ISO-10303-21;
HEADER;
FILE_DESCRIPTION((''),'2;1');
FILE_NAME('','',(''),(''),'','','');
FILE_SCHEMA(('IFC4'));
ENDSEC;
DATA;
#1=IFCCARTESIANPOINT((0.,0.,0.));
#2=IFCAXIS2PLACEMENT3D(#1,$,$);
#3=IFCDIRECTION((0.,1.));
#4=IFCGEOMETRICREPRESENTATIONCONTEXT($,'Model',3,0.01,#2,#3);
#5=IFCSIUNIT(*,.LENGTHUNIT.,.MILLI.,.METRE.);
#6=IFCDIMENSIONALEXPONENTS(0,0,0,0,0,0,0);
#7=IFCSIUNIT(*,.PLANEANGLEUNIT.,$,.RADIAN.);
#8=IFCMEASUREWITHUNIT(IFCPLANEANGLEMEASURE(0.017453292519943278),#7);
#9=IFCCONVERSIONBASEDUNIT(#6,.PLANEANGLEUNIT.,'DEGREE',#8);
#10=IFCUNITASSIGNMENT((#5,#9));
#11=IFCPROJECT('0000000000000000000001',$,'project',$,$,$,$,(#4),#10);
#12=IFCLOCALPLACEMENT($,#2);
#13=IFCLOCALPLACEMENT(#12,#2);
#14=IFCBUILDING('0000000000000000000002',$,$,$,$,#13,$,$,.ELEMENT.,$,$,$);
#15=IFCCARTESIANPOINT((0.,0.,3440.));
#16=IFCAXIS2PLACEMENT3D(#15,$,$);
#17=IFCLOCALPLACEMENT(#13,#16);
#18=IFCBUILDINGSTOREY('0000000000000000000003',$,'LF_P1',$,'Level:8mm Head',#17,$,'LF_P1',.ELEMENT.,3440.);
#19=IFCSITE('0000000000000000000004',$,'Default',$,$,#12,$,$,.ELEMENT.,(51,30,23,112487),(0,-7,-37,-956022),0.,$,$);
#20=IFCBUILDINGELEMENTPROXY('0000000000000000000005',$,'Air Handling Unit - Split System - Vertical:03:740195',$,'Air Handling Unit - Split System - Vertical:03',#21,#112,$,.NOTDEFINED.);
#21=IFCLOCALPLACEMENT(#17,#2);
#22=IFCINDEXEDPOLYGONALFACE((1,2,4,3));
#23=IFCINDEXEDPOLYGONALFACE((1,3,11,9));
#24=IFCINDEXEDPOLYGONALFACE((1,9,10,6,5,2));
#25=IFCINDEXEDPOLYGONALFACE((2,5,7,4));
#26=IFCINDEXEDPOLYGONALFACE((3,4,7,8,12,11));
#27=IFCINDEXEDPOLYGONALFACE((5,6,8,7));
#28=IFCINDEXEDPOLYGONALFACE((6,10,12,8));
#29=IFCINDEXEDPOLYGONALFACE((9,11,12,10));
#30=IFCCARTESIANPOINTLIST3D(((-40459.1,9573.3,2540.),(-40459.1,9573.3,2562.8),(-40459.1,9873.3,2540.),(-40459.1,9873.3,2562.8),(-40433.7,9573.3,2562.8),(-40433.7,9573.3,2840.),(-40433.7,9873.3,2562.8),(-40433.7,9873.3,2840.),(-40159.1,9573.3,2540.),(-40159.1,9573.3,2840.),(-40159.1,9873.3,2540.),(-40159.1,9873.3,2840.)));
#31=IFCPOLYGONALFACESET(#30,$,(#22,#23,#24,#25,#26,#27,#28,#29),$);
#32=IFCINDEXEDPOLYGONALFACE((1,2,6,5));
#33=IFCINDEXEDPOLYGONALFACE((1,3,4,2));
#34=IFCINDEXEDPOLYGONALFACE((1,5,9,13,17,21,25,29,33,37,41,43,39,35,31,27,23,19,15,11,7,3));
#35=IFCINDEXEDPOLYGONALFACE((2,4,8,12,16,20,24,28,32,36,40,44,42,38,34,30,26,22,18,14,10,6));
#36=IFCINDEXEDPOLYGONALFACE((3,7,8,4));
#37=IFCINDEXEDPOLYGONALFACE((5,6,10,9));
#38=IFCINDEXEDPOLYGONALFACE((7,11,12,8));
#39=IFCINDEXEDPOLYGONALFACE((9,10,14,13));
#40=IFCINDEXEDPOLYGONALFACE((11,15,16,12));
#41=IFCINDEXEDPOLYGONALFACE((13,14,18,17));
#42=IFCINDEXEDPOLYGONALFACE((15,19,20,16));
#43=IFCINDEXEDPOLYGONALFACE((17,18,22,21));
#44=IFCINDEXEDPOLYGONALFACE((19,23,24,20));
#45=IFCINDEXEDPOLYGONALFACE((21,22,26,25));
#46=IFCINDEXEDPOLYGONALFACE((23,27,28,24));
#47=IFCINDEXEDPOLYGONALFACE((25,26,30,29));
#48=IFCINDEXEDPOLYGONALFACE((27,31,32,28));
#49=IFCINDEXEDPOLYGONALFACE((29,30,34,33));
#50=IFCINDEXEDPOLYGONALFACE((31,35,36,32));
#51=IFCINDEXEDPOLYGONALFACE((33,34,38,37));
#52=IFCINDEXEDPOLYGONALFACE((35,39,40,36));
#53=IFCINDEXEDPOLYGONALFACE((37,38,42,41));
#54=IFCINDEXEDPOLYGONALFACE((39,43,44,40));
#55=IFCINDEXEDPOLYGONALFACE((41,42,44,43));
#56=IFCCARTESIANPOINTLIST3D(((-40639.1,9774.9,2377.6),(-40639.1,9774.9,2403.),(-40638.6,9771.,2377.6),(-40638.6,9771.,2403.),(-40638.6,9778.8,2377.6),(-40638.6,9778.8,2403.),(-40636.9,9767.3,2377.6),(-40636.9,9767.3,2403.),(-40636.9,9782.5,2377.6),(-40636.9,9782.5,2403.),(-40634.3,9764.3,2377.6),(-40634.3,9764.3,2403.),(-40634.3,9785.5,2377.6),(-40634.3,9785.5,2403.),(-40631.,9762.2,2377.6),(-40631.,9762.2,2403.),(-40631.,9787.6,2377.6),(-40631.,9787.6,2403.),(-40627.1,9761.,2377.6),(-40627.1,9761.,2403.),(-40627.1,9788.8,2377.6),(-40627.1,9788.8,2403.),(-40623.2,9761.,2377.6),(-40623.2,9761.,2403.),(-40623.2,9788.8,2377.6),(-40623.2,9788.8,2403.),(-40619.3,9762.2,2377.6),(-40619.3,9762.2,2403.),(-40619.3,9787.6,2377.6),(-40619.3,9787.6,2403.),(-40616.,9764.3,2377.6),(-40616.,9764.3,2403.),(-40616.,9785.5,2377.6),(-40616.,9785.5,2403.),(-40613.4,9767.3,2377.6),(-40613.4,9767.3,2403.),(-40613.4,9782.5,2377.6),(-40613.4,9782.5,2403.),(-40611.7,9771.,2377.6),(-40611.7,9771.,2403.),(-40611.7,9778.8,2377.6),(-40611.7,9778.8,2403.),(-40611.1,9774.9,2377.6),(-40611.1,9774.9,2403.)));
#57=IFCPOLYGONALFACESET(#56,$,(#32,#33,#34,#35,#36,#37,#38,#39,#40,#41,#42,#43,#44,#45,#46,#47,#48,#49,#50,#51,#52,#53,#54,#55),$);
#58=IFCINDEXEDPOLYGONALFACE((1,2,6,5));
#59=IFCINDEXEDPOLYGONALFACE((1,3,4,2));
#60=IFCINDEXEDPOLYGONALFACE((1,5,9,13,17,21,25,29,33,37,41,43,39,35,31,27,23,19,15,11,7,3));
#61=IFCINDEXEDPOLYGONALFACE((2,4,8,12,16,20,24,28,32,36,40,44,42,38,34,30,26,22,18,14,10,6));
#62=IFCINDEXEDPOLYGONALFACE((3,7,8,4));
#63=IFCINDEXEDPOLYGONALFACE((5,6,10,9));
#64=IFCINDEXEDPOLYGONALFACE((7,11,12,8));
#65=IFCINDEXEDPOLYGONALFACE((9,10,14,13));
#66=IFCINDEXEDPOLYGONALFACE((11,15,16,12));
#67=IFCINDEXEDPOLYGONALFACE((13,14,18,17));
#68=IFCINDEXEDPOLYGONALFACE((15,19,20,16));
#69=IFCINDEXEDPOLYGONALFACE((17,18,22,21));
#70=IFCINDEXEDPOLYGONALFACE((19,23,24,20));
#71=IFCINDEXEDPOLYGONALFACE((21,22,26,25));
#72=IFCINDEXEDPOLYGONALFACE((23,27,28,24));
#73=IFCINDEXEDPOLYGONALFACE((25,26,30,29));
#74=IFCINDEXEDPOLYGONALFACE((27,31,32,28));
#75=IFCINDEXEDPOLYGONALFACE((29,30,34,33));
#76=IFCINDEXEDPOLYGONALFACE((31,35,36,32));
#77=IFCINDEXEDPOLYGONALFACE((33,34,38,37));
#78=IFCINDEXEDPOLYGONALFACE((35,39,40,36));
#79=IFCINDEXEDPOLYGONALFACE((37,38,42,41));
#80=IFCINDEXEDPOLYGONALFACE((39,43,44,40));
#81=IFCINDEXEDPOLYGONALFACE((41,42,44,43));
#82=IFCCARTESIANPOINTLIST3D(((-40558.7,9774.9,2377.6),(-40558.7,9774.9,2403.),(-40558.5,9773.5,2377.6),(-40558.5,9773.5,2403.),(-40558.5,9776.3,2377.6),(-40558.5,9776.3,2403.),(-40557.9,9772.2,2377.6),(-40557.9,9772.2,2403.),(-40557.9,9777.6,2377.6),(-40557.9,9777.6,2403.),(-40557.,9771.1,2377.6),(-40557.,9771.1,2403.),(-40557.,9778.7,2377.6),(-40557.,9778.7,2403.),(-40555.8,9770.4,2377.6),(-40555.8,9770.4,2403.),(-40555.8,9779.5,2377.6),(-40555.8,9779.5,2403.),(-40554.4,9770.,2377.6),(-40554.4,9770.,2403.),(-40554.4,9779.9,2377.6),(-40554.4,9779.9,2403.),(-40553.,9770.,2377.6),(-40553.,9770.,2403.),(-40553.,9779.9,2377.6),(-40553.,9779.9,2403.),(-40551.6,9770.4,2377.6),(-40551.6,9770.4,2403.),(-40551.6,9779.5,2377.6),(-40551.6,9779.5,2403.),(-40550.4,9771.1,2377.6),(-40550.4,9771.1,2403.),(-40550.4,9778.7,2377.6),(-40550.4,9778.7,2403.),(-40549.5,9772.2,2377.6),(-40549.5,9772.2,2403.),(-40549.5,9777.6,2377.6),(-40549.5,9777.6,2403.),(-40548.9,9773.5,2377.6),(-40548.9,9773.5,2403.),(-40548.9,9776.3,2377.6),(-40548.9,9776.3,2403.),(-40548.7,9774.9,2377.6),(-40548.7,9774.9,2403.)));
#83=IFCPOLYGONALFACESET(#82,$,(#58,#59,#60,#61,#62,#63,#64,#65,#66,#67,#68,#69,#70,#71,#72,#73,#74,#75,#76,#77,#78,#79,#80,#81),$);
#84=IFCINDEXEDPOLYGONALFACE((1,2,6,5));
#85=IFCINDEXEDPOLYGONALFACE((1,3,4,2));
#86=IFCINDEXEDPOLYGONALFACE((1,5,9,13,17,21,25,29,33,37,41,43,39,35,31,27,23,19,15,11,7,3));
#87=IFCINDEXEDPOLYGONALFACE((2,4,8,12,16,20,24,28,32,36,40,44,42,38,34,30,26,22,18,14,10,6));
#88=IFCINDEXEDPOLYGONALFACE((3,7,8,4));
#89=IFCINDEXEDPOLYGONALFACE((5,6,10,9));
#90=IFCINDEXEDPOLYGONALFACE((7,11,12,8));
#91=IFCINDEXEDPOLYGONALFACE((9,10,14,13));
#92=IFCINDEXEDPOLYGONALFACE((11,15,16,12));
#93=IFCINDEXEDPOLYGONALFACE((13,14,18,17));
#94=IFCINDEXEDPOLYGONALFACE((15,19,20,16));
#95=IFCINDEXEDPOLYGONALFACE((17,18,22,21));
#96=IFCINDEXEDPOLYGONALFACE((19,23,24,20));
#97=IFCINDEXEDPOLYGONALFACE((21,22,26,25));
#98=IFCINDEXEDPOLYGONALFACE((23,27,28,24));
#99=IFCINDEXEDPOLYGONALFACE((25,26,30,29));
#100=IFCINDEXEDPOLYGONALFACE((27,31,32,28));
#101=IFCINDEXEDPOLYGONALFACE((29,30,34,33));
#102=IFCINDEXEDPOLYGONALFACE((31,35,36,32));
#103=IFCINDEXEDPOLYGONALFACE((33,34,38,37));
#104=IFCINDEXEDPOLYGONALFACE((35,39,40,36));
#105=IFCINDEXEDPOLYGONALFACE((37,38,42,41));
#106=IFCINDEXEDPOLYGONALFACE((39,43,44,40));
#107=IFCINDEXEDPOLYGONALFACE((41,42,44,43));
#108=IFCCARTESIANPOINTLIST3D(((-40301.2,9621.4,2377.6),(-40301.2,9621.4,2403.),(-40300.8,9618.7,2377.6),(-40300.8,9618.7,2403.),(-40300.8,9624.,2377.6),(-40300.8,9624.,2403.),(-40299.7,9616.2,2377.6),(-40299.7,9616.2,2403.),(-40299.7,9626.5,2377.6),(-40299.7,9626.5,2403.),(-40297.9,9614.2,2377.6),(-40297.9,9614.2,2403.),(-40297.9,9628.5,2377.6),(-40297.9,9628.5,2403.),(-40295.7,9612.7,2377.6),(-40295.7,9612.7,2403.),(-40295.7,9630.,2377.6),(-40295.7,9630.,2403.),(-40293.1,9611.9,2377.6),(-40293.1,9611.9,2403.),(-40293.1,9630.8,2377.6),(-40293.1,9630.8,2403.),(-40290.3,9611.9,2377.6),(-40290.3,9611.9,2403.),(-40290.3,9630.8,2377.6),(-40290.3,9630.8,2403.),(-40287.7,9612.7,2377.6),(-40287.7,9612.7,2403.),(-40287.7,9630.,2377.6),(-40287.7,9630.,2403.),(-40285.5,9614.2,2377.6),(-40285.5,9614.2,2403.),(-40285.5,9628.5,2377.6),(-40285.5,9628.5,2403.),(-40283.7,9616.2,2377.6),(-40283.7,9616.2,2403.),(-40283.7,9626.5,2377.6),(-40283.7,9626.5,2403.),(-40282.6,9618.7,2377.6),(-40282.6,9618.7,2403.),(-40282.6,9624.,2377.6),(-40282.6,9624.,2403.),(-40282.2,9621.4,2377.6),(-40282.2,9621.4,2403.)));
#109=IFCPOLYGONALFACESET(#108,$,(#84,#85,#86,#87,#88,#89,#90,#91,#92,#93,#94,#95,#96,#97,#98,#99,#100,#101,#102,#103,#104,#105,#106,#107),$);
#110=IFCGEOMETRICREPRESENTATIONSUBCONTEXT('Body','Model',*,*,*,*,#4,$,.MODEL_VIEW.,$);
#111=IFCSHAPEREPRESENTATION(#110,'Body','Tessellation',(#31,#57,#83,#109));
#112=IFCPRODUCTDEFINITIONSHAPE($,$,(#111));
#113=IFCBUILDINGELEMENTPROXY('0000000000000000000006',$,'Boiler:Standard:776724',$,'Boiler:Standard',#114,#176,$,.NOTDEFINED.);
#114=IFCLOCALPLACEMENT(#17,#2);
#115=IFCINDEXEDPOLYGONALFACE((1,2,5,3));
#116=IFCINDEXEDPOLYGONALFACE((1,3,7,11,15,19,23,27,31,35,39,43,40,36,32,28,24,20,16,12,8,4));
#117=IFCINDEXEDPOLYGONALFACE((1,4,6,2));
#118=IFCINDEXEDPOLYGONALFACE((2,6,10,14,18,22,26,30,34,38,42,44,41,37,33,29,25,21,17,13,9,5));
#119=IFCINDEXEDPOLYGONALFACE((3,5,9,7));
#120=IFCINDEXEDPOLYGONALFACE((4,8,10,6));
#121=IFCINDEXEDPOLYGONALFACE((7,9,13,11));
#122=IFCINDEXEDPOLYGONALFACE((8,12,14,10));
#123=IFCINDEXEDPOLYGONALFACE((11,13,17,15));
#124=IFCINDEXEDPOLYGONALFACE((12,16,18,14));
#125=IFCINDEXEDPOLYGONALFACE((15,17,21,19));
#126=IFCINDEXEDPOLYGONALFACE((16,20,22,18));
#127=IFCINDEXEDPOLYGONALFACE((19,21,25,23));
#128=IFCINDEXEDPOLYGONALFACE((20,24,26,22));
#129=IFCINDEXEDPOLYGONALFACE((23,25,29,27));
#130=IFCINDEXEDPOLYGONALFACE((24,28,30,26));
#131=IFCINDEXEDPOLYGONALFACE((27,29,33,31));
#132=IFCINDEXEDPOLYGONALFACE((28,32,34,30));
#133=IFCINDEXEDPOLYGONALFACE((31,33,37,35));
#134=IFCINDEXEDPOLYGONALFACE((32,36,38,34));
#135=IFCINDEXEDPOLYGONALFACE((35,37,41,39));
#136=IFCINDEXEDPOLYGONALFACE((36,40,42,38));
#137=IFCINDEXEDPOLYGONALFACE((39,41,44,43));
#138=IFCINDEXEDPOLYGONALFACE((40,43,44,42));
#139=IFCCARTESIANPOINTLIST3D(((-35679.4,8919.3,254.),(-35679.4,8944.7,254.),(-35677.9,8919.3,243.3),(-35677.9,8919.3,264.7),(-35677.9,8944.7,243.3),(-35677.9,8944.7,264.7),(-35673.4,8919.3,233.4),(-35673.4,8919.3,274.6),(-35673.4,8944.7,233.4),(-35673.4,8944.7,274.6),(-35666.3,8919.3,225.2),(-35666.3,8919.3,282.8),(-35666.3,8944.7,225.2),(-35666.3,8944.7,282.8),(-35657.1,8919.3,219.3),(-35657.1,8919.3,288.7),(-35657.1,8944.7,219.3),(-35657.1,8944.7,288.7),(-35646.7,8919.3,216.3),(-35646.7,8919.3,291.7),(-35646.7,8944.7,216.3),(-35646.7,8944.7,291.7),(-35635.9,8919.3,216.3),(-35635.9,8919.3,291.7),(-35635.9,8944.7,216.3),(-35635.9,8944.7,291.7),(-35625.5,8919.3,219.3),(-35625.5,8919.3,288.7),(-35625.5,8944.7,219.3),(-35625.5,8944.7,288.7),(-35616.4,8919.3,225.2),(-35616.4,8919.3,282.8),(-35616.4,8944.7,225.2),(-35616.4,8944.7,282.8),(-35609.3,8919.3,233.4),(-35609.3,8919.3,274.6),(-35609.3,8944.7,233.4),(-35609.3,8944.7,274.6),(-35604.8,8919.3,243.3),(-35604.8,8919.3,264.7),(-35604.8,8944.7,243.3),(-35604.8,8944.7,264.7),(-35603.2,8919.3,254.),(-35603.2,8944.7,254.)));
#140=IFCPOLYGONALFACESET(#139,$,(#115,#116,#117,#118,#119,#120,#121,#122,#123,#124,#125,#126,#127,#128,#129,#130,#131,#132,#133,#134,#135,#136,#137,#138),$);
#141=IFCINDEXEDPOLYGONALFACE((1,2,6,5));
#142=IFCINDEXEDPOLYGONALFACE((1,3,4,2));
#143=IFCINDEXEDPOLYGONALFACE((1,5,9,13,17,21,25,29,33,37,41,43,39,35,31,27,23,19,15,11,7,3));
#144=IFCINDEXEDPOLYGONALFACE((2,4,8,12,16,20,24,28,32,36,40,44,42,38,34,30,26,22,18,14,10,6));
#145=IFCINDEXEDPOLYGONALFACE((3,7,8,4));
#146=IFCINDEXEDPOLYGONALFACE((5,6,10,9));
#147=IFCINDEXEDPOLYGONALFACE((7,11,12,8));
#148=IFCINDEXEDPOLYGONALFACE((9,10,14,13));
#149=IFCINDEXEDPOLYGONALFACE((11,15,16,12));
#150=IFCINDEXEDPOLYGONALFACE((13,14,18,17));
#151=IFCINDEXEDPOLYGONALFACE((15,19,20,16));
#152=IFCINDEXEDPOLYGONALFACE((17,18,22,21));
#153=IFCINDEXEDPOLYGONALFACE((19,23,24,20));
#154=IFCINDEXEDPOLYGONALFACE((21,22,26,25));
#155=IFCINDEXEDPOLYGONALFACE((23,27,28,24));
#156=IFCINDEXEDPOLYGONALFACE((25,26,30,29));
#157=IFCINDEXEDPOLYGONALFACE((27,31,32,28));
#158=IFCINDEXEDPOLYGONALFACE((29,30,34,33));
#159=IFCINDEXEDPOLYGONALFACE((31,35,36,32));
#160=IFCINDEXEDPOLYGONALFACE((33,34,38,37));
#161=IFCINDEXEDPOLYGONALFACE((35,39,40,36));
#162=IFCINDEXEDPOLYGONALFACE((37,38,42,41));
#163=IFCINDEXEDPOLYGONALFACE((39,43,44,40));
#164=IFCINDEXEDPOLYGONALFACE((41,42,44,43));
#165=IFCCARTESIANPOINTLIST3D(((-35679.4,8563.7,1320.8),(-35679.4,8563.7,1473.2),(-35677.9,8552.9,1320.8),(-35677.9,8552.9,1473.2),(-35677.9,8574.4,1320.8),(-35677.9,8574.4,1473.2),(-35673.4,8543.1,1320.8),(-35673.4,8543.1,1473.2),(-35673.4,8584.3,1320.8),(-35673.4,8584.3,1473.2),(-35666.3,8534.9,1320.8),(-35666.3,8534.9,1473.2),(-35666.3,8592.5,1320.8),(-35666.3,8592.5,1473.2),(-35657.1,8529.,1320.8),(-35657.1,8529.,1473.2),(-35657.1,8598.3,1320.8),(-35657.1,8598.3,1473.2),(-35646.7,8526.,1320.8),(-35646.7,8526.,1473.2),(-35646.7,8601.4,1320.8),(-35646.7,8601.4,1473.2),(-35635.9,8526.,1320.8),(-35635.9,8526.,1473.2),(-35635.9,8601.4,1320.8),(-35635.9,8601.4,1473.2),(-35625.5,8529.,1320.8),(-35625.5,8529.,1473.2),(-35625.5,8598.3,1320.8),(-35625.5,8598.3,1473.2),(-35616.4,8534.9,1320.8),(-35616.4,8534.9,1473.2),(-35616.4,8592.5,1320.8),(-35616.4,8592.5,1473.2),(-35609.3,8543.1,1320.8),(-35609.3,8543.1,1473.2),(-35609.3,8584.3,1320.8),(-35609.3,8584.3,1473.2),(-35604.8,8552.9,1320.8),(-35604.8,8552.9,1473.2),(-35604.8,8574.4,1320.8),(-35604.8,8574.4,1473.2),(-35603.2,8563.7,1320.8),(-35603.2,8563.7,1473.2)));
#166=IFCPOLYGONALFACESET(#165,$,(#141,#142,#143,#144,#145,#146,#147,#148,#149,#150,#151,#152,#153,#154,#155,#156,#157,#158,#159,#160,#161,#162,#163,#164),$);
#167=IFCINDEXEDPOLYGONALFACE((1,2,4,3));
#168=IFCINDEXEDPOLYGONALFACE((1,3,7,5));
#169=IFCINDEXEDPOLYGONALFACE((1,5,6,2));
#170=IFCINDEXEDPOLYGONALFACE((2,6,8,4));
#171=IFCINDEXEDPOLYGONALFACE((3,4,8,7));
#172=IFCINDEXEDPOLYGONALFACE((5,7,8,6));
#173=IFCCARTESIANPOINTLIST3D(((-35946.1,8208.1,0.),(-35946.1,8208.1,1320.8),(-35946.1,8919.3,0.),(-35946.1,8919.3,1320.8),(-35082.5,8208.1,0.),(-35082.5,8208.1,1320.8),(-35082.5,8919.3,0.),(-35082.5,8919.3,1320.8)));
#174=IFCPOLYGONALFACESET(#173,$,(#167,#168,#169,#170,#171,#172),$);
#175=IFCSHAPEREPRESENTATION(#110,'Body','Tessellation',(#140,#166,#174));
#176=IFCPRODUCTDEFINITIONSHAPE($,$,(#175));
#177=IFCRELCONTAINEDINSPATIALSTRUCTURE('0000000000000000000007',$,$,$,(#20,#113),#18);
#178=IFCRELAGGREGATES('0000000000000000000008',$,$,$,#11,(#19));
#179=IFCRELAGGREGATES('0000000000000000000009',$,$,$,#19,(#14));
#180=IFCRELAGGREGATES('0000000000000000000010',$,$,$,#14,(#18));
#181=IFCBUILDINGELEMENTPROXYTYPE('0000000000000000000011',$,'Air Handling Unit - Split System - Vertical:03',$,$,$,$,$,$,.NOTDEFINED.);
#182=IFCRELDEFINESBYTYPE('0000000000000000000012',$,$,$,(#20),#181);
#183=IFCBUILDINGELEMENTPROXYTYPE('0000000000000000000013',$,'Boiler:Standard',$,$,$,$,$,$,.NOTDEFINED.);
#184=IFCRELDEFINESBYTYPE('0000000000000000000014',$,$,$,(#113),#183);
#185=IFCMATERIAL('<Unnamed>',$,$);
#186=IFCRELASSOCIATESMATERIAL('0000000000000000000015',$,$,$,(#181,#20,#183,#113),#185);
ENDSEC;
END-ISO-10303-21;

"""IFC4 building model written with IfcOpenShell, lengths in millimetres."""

from ifc_helpers import new_model, entity, si_unit, converted_unit, direction, frame, origin, place, context, subcontext, project, spatial, arc, indexed_curve, outline, extrude, source, transform, mapped, material, type_object, type_shapes, element, save


model = new_model("IFC4")

# Units and contexts
model_context = context("Model", 3, precision=0.01, world=origin(), true_north=direction((0.0, 1.0)))
body_context = subcontext(model_context, "Body", "Model", "MODEL_VIEW")
ifc_project = project(units=[si_unit("LENGTHUNIT", "METRE", prefix="MILLI"), converted_unit("PLANEANGLEUNIT", "DEGREE", entity("IfcPlaneAngleMeasure", 0.017453292519943278), si_unit("PLANEANGLEUNIT", "RADIAN"), dimensions=[0, 0, 0, 0, 0, 0, 0])], contexts=[model_context])

# Site, building, storey
site_placement = place(None, origin())
site = spatial("IfcSite", under=ifc_project, at=site_placement, Name="Default", CompositionType="ELEMENT", RefLatitude=(51, 30, 23, 112487), RefLongitude=(0, -7, -37, -956022), RefElevation=0.0)
building_placement = place(site_placement, origin())
building = spatial("IfcBuilding", under=site, at=building_placement, CompositionType="ELEMENT")
storey_placement = place(building_placement, frame((0.0, 0.0, 3440.0)))
storey = spatial("IfcBuildingStorey", under=building, at=storey_placement, Name="LF_P1", ObjectType="Level:8mm Head", LongName="LF_P1", CompositionType="ELEMENT", Elevation=3440.0)

# Shared definitions
ifc_material = material(Name="<Unnamed>")

# Building element proxies
building_element_proxy_type_1 = type_object("IfcBuildingElementProxyType", Name="Air Handling Unit - Split System - Vertical:03", PredefinedType="NOTDEFINED", material=ifc_material)
shared_shape_1 = source(origin(), body_context, "Body", "SweptSolid", [
    extrude(outline(indexed_curve([(-191.5, -107.6), (108.5, -107.6), (108.5, -84.8), (83.1, -84.8), (83.1, 192.4), (-191.5, 192.4), (-191.5, -107.6)], self_intersect=False)), frame((-150.0, 42.4, 191.5), z_axis=(1.0, 0.0, 0.0), x_axis=(0.0, 0.0, 1.0)), (0.0, 0.0, 1.0), 300.0),
    extrude(outline(indexed_curve([(-14.0, 0.0), (0.0, -14.0), (14.0, 0.0), (0.0, 14.0)], segments=[arc(1, 2, 3), arc(3, 4, 1)], self_intersect=False)), frame((51.6, 287.0, 466.0), z_axis=(0.0, 1.0, 0.0), x_axis=(0.0, 0.0, -1.0)), (0.0, 0.0, 1.0), 25.4),
    extrude(outline(indexed_curve([(-5.0, 0.0), (0.0, -5.0), (5.0, 0.0), (0.0, 5.0)], segments=[arc(1, 2, 3), arc(3, 4, 1)], self_intersect=False)), frame((51.6, 287.0, 394.6), z_axis=(0.0, 1.0, 0.0), x_axis=(0.0, 0.0, -1.0)), (0.0, 0.0, 1.0), 25.4),
    extrude(outline(indexed_curve([(-9.5, 0.0), (0.0, -9.5), (9.5, 0.0), (0.0, 9.5)], segments=[arc(1, 2, 3), arc(3, 4, 1)], self_intersect=False)), frame((-102.0, 287.0, 132.6), z_axis=(0.0, 1.0, 0.0), x_axis=(0.0, 0.0, -1.0)), (0.0, 0.0, 1.0), 25.4),
])
type_shapes(building_element_proxy_type_1, [shared_shape_1])
for number, where, z_axis, x_axis, name in (
    (1, (-40159.1, 9723.3, 2690.0), (-1.0, 0.0, 0.0), (0.0, 1.0, 0.0), "Air Handling Unit - Split System - Vertical:03:740195"),
):
    element("IfcBuildingElementProxy", number, at=place(storey_placement, frame(where, z_axis=z_axis, x_axis=x_axis)), inside=storey, type_object=building_element_proxy_type_1, material=ifc_material, Name=name, ObjectType="Air Handling Unit - Split System - Vertical:03", PredefinedType="NOTDEFINED", context=body_context, shape_type="MappedRepresentation", body=[
        mapped(shared_shape_1, transform((0.0, 0.0, 0.0), scale=1.0)),
    ])
building_element_proxy_type_2 = type_object("IfcBuildingElementProxyType", Name="Boiler:Standard", PredefinedType="NOTDEFINED", material=ifc_material)
shared_shape_2 = source(origin(), body_context, "Body", "SweptSolid", [
    extrude(outline(indexed_curve([(-38.1, 0.0), (0.0, -38.1), (38.1, 0.0), (0.0, 38.1)], segments=[arc(1, 2, 3), arc(3, 4, 1)], self_intersect=False)), frame((304.8, 711.2, 254.0), z_axis=(0.0, 1.0, 0.0), x_axis=(-1.0, 0.0, 0.0)), (0.0, 0.0, 1.0), 25.4),
    extrude(outline(indexed_curve([(-38.1, 0.0), (0.0, -38.1), (38.1, 0.0), (0.0, 38.1)], segments=[arc(1, 2, 3), arc(3, 4, 1)], self_intersect=False)), frame((304.8, 355.6, 1320.8)), (0.0, 0.0, 1.0), 152.4),
    extrude(outline(indexed_curve([(-355.6, -431.8), (355.6, -431.8), (355.6, 431.8), (-355.6, 431.8), (-355.6, -431.8)], self_intersect=False)), frame((431.8, 355.6, 0.0), z_axis=(0.0, 0.0, 1.0), x_axis=(0.0, 1.0, 0.0)), (0.0, 0.0, 1.0), 1320.8),
])
type_shapes(building_element_proxy_type_2, [shared_shape_2])
proxy_placement = place(storey_placement, frame((-35946.1, 8208.1, 0.0)))
element("IfcBuildingElementProxy", 2, at=proxy_placement, inside=storey, type_object=building_element_proxy_type_2, material=ifc_material, Name="Boiler:Standard:776724", ObjectType="Boiler:Standard", PredefinedType="NOTDEFINED", context=body_context, shape_type="MappedRepresentation", body=[
    mapped(shared_shape_2, transform((0.0, 0.0, 0.0), scale=1.0)),
])

save(model, "model.ifc")
